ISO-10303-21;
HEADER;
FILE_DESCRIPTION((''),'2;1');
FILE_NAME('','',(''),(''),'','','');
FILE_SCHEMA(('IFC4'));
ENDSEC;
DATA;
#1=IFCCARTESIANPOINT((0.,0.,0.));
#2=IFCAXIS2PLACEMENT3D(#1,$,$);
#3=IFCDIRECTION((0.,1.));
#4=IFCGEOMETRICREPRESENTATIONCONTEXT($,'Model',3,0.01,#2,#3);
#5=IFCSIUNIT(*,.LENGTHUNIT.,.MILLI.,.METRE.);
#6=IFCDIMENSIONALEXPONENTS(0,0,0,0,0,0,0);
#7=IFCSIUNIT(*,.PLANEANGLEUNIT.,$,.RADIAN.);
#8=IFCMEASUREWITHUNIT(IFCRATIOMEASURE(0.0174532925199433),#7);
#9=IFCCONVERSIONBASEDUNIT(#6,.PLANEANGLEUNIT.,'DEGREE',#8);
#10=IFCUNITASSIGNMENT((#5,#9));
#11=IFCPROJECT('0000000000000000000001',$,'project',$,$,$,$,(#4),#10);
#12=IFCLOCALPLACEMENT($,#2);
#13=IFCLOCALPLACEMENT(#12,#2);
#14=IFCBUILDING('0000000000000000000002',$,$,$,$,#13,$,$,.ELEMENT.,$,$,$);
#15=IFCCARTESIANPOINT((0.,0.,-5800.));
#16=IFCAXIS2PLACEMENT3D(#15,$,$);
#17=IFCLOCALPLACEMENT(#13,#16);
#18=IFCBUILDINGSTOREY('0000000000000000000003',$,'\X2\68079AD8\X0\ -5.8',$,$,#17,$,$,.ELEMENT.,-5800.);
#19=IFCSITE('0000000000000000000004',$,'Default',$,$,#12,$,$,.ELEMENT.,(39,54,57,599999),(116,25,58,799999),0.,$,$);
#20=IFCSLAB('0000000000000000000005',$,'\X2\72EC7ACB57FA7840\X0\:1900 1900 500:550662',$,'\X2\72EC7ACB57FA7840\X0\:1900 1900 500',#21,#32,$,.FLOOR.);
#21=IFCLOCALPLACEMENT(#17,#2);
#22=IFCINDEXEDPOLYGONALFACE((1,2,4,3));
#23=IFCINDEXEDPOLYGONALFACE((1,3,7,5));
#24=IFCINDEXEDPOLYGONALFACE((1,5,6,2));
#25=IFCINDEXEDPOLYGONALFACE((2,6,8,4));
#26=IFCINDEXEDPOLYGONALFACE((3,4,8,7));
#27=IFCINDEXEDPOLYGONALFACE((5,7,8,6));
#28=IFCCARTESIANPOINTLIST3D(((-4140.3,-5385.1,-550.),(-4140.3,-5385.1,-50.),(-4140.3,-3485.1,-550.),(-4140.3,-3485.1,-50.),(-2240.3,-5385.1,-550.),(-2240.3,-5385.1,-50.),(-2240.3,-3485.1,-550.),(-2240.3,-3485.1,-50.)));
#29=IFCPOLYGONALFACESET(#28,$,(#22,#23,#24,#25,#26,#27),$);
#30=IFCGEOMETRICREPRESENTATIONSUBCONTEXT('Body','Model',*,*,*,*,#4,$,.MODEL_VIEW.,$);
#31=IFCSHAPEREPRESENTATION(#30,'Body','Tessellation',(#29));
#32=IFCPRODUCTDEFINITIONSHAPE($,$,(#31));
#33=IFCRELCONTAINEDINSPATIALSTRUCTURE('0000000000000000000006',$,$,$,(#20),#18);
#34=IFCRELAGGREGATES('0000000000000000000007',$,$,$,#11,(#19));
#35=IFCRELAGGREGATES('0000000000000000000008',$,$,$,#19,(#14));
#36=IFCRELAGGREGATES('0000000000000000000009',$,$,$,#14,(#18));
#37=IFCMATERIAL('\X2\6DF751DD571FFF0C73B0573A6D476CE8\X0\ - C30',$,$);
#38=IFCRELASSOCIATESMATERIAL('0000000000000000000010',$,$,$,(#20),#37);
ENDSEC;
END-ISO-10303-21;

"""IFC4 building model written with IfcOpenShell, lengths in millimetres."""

from ifc_helpers import new_model, entity, si_unit, converted_unit, direction, frame, frame_2d, origin, place, context, subcontext, project, spatial, rectangle, extrude, material, element, save


model = new_model("IFC4")

# Units and contexts
model_context = context("Model", 3, precision=0.01, world=origin(), true_north=direction((0.0, 1.0)))
body_context = subcontext(model_context, "Body", "Model", "MODEL_VIEW")
ifc_project = project(units=[si_unit("LENGTHUNIT", "METRE", prefix="MILLI"), converted_unit("PLANEANGLEUNIT", "DEGREE", entity("IfcRatioMeasure", 0.0174532925199433), si_unit("PLANEANGLEUNIT", "RADIAN"), dimensions=[0, 0, 0, 0, 0, 0, 0])], contexts=[model_context])

# Site, building, storey
site_placement = place(None, origin())
site = spatial("IfcSite", under=ifc_project, at=site_placement, Name="Default", CompositionType="ELEMENT", RefLatitude=(39, 54, 57, 599999), RefLongitude=(116, 25, 58, 799999), RefElevation=0.0)
building_placement = place(site_placement, origin())
building = spatial("IfcBuilding", under=site, at=building_placement, CompositionType="ELEMENT")
storey_placement = place(building_placement, frame((0.0, 0.0, -5800.0)))
storey = spatial("IfcBuildingStorey", under=building, at=storey_placement, Name="标高 -5.8", CompositionType="ELEMENT", Elevation=-5800.0)

# Slab
ifc_material = material(Name="混凝土，现场浇注 - C30")
slab_placement = place(storey_placement, frame((-4140.3, -5385.1, -550.0)))
element("IfcSlab", 1, at=slab_placement, inside=storey, material=ifc_material, Name="独立基础:1900 1900 500:550662", ObjectType="独立基础:1900 1900 500", PredefinedType="FLOOR", context=body_context, shape_type="SweptSolid", body=[
    extrude(rectangle(XDim=1900.0, YDim=1900.0, at=frame_2d((0.0, 0.0), x_axis=(1.0, 0.0))), frame((950.0, 950.0, 0.0), z_axis=(0.0, 0.0, 1.0), x_axis=(-1.0, 0.0, 0.0)), (0.0, 0.0, 1.0), 500.0),
])

save(model, "model.ifc")
